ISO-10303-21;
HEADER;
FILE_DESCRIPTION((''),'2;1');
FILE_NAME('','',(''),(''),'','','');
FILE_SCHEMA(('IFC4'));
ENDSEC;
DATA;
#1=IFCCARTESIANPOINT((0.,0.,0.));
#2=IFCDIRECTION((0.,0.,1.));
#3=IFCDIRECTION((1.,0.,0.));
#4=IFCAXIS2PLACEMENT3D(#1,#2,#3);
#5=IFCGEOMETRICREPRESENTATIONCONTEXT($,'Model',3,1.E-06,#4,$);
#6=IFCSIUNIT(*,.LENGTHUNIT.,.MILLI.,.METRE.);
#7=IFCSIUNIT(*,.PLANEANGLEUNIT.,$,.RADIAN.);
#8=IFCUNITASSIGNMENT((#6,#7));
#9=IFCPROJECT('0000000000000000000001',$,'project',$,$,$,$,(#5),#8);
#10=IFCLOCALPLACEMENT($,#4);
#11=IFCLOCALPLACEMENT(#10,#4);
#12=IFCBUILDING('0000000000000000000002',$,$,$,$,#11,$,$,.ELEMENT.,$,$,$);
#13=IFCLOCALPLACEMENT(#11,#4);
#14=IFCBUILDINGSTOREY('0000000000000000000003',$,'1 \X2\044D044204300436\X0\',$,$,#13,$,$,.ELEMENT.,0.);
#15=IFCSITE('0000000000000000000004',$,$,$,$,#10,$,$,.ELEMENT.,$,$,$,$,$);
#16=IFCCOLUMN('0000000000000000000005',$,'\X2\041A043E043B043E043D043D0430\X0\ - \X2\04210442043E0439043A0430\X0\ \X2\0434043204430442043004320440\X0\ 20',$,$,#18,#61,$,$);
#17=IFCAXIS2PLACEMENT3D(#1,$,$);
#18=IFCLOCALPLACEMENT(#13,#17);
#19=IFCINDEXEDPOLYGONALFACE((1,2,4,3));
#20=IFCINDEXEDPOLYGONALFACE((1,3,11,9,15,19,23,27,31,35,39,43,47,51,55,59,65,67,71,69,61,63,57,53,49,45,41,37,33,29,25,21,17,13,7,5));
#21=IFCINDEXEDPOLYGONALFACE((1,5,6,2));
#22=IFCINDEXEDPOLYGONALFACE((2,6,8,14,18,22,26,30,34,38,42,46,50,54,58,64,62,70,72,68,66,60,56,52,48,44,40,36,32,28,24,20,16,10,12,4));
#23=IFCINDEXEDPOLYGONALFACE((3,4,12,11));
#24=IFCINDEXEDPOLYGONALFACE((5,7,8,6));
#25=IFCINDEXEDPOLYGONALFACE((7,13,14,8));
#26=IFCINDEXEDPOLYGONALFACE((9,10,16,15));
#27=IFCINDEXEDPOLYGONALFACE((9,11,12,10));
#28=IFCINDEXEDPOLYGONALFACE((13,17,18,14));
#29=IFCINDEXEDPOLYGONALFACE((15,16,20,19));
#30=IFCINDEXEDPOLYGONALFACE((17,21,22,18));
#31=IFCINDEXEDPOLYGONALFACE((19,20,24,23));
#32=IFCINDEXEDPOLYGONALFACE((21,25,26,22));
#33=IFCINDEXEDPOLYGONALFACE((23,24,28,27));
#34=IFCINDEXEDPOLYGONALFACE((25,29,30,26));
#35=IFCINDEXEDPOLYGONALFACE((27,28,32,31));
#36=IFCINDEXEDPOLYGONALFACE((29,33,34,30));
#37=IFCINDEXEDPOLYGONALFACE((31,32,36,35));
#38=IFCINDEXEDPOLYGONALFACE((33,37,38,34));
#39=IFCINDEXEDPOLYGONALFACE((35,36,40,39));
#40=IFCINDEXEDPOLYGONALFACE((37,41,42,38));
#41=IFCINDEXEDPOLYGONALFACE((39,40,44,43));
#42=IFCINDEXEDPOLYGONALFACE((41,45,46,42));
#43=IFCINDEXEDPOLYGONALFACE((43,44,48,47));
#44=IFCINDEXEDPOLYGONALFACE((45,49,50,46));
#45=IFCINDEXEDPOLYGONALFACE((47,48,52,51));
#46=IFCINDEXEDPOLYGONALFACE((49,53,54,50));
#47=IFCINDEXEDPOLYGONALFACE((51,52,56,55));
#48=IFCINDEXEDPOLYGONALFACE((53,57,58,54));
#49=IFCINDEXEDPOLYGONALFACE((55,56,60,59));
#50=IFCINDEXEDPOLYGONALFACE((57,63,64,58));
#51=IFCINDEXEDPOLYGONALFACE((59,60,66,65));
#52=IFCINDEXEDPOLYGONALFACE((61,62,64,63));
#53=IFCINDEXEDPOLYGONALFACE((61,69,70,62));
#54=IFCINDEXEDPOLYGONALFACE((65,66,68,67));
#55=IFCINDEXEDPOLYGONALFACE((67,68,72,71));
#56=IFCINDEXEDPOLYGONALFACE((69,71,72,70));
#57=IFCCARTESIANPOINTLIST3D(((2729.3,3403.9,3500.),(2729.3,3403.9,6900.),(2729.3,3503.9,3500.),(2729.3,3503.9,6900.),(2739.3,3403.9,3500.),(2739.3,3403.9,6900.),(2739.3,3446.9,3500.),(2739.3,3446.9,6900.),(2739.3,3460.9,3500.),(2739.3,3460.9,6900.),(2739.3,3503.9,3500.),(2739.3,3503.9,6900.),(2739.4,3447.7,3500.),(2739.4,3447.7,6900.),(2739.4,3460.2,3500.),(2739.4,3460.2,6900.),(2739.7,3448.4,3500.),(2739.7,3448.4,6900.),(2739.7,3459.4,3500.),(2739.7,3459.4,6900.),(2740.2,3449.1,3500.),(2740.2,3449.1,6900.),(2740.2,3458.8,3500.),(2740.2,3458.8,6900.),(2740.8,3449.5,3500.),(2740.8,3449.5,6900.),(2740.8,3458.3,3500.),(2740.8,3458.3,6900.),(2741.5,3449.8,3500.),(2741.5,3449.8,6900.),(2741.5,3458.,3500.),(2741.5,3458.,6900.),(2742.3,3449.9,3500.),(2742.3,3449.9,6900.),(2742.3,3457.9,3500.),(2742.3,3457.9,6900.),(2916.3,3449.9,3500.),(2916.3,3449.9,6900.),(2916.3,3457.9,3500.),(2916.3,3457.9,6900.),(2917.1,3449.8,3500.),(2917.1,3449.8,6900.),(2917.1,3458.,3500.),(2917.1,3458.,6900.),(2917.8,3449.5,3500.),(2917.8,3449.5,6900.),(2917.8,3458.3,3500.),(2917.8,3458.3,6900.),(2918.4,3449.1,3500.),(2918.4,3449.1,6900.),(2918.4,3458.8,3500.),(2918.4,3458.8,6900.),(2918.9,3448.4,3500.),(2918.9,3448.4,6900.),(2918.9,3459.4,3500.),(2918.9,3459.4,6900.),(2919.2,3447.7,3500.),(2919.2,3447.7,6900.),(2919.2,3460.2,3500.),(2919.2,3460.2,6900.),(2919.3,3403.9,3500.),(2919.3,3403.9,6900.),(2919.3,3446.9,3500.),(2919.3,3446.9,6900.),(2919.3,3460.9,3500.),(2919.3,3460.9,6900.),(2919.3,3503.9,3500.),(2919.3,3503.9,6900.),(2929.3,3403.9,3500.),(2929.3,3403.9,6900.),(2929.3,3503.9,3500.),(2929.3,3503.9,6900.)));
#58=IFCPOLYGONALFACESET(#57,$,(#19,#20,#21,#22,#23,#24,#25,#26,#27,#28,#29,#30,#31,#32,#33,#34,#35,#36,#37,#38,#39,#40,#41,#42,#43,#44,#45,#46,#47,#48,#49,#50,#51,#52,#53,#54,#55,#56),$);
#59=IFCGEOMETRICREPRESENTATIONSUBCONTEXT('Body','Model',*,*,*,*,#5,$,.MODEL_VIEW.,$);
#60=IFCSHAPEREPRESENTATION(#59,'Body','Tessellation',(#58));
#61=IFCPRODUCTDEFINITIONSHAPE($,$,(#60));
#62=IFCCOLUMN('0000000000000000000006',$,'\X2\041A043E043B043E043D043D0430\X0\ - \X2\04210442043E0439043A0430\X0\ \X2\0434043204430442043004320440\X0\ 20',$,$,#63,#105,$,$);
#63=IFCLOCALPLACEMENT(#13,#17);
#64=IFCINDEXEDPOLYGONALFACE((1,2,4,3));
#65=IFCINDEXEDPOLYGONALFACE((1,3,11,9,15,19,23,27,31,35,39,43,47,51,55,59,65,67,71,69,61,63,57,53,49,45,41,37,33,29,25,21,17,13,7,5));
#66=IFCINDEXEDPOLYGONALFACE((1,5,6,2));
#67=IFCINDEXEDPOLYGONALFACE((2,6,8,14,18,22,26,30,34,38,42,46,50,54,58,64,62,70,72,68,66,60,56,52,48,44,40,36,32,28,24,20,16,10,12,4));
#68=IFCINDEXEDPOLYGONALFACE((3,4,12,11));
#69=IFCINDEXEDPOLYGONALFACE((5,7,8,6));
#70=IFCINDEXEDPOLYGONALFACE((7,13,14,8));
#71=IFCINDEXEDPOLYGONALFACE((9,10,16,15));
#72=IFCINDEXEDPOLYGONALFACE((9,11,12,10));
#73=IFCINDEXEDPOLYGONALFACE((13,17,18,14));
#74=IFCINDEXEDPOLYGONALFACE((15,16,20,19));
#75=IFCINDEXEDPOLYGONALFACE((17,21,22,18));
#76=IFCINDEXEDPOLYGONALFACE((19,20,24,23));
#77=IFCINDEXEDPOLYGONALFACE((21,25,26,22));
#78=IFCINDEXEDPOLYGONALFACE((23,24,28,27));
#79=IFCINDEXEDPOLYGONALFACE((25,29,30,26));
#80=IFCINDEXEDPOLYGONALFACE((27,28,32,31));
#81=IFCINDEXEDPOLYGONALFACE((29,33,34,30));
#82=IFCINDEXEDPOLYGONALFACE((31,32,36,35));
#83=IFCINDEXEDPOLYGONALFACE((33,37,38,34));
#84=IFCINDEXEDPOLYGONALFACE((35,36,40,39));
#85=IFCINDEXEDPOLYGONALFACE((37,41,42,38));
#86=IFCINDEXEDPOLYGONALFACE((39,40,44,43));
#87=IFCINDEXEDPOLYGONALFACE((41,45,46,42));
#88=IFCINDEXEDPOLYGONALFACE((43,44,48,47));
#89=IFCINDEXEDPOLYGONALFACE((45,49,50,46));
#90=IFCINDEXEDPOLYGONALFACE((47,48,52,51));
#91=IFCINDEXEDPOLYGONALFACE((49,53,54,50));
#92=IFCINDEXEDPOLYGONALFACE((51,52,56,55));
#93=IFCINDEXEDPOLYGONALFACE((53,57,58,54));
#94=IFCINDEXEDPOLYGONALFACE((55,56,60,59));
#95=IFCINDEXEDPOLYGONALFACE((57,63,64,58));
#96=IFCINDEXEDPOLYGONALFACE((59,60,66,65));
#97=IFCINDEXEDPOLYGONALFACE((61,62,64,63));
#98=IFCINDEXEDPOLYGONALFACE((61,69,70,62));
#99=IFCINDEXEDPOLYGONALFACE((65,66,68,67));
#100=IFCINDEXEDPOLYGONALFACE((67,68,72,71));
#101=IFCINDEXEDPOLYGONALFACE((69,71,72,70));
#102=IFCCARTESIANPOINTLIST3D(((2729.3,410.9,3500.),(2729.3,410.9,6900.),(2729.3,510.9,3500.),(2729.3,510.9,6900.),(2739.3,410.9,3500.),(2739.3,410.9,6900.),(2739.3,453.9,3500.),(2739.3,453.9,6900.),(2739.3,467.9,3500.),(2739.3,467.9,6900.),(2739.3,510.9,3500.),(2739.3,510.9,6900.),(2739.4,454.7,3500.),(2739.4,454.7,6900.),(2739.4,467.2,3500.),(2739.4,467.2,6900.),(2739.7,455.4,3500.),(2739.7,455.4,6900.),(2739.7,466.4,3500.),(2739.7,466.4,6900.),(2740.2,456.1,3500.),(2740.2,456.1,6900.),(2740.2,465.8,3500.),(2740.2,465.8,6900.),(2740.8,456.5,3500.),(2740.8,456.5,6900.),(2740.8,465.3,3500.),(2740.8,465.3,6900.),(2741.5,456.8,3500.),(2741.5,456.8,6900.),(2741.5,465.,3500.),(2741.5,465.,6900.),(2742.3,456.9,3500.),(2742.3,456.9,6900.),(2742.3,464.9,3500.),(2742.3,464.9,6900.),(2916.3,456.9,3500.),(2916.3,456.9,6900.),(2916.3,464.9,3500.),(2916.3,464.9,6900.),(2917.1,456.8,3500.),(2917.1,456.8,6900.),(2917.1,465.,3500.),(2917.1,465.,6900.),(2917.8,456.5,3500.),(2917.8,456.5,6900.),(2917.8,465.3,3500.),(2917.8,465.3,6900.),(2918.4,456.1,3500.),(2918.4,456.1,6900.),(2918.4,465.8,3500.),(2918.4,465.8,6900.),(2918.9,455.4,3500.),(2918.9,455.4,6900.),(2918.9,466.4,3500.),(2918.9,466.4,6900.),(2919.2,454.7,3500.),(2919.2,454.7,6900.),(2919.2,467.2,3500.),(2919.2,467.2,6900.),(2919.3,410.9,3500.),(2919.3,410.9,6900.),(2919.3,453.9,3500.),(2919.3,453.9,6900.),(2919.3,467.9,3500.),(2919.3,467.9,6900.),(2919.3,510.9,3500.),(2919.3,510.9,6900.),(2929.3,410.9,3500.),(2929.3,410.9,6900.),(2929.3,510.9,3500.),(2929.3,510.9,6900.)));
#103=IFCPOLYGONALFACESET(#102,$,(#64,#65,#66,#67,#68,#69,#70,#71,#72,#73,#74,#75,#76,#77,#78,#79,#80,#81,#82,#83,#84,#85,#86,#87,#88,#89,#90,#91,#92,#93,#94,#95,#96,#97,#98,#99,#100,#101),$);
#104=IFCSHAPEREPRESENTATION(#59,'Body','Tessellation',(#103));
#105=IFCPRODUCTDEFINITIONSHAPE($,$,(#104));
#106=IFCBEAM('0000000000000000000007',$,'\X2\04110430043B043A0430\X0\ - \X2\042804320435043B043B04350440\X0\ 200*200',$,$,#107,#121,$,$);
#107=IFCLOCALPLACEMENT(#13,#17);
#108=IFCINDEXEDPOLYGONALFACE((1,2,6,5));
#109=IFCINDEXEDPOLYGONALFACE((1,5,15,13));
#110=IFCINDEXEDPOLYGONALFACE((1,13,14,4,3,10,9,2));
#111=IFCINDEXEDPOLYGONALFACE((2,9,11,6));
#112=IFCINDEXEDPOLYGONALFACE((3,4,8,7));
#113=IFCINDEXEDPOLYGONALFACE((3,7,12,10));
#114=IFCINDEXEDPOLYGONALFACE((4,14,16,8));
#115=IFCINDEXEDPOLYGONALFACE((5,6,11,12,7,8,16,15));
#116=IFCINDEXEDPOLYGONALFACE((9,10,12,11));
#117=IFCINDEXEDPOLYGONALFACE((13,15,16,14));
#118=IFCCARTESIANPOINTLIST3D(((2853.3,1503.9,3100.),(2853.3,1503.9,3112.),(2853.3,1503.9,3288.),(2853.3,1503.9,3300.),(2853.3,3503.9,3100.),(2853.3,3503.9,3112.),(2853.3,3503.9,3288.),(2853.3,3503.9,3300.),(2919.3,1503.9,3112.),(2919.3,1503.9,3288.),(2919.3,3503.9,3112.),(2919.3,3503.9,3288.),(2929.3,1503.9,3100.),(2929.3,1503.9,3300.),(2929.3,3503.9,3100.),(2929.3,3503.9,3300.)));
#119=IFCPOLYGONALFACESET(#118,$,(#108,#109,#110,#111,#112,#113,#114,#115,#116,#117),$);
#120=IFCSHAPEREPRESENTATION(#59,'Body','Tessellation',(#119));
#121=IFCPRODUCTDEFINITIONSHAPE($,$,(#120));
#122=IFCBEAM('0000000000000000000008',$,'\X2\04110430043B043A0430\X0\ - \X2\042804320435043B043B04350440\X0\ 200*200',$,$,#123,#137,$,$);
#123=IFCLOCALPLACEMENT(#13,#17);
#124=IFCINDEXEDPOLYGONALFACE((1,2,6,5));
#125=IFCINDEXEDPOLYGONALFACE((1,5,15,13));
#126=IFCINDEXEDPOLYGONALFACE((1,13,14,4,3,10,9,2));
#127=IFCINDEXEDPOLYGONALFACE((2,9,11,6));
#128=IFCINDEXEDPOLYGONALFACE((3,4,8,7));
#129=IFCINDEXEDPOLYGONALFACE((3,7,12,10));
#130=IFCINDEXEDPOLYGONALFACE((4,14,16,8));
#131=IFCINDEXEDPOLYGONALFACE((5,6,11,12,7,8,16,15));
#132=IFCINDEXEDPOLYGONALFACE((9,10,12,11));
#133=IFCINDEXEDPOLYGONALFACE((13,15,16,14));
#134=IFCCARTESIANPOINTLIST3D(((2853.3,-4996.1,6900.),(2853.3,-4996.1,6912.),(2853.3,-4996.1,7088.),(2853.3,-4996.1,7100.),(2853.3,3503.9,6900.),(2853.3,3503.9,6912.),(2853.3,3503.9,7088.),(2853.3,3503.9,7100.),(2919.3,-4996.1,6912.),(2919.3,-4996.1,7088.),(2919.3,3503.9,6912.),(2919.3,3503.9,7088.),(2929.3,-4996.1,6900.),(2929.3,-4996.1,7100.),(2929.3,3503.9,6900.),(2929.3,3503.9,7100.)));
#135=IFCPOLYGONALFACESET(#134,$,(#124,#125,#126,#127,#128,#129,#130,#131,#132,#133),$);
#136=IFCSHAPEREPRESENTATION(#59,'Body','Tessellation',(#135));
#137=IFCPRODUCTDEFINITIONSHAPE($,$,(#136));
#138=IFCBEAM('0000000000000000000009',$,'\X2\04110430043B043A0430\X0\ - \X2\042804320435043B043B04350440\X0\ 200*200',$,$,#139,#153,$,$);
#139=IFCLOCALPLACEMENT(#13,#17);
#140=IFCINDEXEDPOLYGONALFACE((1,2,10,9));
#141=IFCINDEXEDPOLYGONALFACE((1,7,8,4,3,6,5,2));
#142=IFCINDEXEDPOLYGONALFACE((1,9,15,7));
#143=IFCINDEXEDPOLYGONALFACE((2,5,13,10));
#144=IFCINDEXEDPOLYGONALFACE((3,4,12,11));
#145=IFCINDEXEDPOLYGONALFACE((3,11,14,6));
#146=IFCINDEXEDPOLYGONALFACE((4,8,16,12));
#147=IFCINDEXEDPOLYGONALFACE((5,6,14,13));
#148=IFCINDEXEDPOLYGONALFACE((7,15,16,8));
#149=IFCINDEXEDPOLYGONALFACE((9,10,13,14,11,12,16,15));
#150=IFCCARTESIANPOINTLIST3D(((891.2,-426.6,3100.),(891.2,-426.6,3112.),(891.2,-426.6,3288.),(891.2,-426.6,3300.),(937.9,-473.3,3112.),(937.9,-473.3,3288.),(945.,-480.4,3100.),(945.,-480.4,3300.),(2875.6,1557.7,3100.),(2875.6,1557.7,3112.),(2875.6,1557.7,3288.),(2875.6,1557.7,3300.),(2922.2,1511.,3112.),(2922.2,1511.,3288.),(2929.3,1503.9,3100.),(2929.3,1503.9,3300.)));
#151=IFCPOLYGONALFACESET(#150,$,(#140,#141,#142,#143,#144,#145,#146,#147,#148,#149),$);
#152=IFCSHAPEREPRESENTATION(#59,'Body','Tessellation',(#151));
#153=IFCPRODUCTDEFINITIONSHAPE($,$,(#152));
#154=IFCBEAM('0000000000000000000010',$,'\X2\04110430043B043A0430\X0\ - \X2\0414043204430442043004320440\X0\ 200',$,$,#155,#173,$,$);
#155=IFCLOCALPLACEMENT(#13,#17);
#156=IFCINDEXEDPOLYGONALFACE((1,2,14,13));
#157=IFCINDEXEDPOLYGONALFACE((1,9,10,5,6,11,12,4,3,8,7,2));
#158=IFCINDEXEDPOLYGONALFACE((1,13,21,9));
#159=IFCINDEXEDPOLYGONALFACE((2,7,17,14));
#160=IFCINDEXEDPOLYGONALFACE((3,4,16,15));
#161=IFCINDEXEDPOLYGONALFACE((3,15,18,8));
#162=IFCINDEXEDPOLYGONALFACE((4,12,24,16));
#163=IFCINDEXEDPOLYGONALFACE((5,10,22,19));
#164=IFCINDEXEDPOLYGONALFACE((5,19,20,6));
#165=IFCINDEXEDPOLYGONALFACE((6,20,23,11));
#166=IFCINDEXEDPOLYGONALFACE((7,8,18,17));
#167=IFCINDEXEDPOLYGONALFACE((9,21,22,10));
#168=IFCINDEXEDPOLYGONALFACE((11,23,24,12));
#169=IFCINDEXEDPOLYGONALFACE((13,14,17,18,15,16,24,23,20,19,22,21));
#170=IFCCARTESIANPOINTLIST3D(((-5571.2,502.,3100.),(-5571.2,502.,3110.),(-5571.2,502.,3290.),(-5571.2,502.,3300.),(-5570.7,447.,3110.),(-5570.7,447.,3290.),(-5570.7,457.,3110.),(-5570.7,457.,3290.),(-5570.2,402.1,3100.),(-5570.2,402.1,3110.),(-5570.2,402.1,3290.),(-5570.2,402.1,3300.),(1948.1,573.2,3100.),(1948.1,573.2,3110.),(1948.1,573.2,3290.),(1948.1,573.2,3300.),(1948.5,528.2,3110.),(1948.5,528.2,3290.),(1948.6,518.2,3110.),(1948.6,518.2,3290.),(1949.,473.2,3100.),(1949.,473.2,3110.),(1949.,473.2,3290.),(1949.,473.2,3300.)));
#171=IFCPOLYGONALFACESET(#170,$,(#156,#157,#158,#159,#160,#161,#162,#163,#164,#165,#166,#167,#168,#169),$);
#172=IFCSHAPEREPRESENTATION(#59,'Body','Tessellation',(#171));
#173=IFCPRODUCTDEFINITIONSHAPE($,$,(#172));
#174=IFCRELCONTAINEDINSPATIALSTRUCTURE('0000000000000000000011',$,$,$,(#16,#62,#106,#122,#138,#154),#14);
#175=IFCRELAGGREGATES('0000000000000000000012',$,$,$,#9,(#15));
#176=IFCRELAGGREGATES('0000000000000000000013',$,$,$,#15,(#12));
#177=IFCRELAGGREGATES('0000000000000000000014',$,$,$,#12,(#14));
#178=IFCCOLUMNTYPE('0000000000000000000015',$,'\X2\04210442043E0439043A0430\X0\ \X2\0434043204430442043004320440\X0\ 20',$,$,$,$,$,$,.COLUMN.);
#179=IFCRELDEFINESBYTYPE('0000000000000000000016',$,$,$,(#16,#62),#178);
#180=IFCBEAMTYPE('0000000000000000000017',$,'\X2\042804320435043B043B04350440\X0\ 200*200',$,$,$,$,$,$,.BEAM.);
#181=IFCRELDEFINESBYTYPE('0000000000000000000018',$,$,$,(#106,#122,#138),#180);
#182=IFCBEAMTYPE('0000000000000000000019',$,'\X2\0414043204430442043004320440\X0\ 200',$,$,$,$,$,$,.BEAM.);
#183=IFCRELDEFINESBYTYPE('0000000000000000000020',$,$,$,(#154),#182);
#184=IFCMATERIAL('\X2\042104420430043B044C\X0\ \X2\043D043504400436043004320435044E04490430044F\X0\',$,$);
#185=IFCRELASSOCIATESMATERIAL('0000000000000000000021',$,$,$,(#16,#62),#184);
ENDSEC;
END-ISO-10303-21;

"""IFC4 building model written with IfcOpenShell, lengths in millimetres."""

from ifc_helpers import new_model, si_unit, frame, origin_with_axes, place, context, subcontext, project, spatial, line, arc, indexed_curve, outline, extrude, source, transform, mapped, material, type_object, element, save


model = new_model("IFC4")

# Units and contexts
model_context = context("Model", 3, precision=1e-06, world=origin_with_axes())
body_context = subcontext(model_context, "Body", "Model", "MODEL_VIEW")
ifc_project = project(units=[si_unit("LENGTHUNIT", "METRE", prefix="MILLI"), si_unit("PLANEANGLEUNIT", "RADIAN")], contexts=[model_context])

# Site, building, storey
site_placement = place(None, origin_with_axes())
site = spatial("IfcSite", under=ifc_project, at=site_placement, CompositionType="ELEMENT")
building_placement = place(site_placement, origin_with_axes())
building = spatial("IfcBuilding", under=site, at=building_placement, CompositionType="ELEMENT")
storey_placement = place(building_placement, origin_with_axes())
storey = spatial("IfcBuildingStorey", under=building, at=storey_placement, Name="1 этаж", CompositionType="ELEMENT", Elevation=0.0)

# Columns
ifc_material_1 = material(Name="Сталь нержавеющая")
column_type = type_object("IfcColumnType", Name="Стойка двутавр 20", PredefinedType="COLUMN")
shared_shape_1 = source(origin_with_axes(), body_context, "Body", "SweptSolid", [
    extrude(outline(indexed_curve([(-50.0, -100.0), (50.0, -100.0), (50.0, -90.0), (7.0, -90.0), (4.9, -89.1), (4.0, -87.0), (4.0, 87.0), (4.9, 89.1), (7.0, 90.0), (50.0, 90.0), (50.0, 100.0), (-50.0, 100.0), (-50.0, 90.0), (-7.0, 90.0), (-4.9, 89.1), (-4.0, 87.0), (-4.0, -87.0), (-4.9, -89.1), (-7.0, -90.0), (-50.0, -90.0)], segments=[line(1, 2), line(2, 3), line(3, 4), arc(4, 5, 6), line(6, 7), arc(7, 8, 9), line(9, 10), line(10, 11), line(11, 12), line(12, 13), line(13, 14), arc(14, 15, 16), line(16, 17), arc(17, 18, 19), line(19, 20), line(20, 1)])), origin_with_axes(), (0.0, 0.0, 1.0), 3400.0),
])
for number, where, z_axis, x_axis, name in (
    (1, (2829.3, 3453.9, 3500.0), (0.0, 0.0, 1.0), (0.0, -1.0, 0.0), "Колонна - Стойка двутавр 20"),
    (2, (2829.3, 460.9, 3500.0), (0.0, 0.0, 1.0), (0.0, -1.0, 0.0), "Колонна - Стойка двутавр 20"),
):
    element("IfcColumn", number, at=place(storey_placement, frame(where, z_axis=z_axis, x_axis=x_axis)), inside=storey, type_object=column_type, material=ifc_material_1, Name=name, context=body_context, shape_type="MappedRepresentation", body=[
        mapped(shared_shape_1, transform((0.0, 0.0, 0.0), x_axis=(1.0, 0.0, 0.0), y_axis=(0.0, 1.0, 0.0), z_axis=(0.0, 0.0, 1.0), scale=1.0)),
    ])

# Beams
beam_type_1 = type_object("IfcBeamType", Name="Швеллер 200*200", PredefinedType="BEAM")
shared_shape_2 = source(origin_with_axes(), body_context, "Body", "SweptSolid", [
    extrude(outline(indexed_curve([(0.0, 0.0), (76.0, 0.0), (76.0, 12.0), (10.0, 12.0), (10.0, 188.0), (76.0, 188.0), (76.0, 200.0), (0.0, 200.0)], segments=[line(1, 2), line(2, 3), line(3, 4), line(4, 5), line(5, 6), line(6, 7), line(7, 8), line(8, 1)])), origin_with_axes(), (0.0, 0.0, -1.0), 2000.0),
])
beam_1_placement = place(storey_placement, frame((2929.3, 3503.9, 3100.0), z_axis=(0.0, 1.0, 0.0), x_axis=(-1.0, 0.0, 0.0)))
element("IfcBeam", 3, at=beam_1_placement, inside=storey, type_object=beam_type_1, Name="Балка - Швеллер 200*200", context=body_context, shape_type="MappedRepresentation", body=[
    mapped(shared_shape_2, transform((0.0, 0.0, 0.0), x_axis=(1.0, 0.0, 0.0), y_axis=(0.0, 1.0, 0.0), z_axis=(0.0, 0.0, 1.0), scale=1.0)),
])
shared_shape_3 = source(origin_with_axes(), body_context, "Body", "SweptSolid", [
    extrude(outline(indexed_curve([(0.0, 0.0), (76.0, 0.0), (76.0, 12.0), (10.0, 12.0), (10.0, 188.0), (76.0, 188.0), (76.0, 200.0), (0.0, 200.0)], segments=[line(1, 2), line(2, 3), line(3, 4), line(4, 5), line(5, 6), line(6, 7), line(7, 8), line(8, 1)])), origin_with_axes(), (0.0, 0.0, -1.0), 8500.0),
])
beam_2_placement = place(storey_placement, frame((2929.3, 3503.9, 6900.0), z_axis=(0.0, 1.0, 0.0), x_axis=(-1.0, 0.0, 0.0)))
element("IfcBeam", 4, at=beam_2_placement, inside=storey, type_object=beam_type_1, Name="Балка - Швеллер 200*200", context=body_context, shape_type="MappedRepresentation", body=[
    mapped(shared_shape_3, transform((0.0, 0.0, 0.0), x_axis=(1.0, 0.0, 0.0), y_axis=(0.0, 1.0, 0.0), z_axis=(0.0, 0.0, 1.0), scale=1.0)),
])
shared_shape_4 = source(origin_with_axes(), body_context, "Body", "SweptSolid", [
    extrude(outline(indexed_curve([(0.0, 0.0), (76.0, 0.0), (76.0, 12.0), (10.0, 12.0), (10.0, 188.0), (76.0, 188.0), (76.0, 200.0), (0.0, 200.0)], segments=[line(1, 2), line(2, 3), line(3, 4), line(4, 5), line(5, 6), line(6, 7), line(7, 8), line(8, 1)])), origin_with_axes(), (0.0, 0.0, -1.0), 2806.2),
])
beam_3_placement = place(storey_placement, frame((2929.3, 1503.9, 3100.0), z_axis=(0.707107, 0.707107, 0.0), x_axis=(-0.707107, 0.707107, 0.0)))
element("IfcBeam", 5, at=beam_3_placement, inside=storey, type_object=beam_type_1, Name="Балка - Швеллер 200*200", context=body_context, shape_type="MappedRepresentation", body=[
    mapped(shared_shape_4, transform((0.0, 0.0, 0.0), x_axis=(1.0, 0.0, 0.0), y_axis=(0.0, 1.0, 0.0), z_axis=(0.0, 0.0, 1.0), scale=1.0)),
])
beam_type_2 = type_object("IfcBeamType", Name="Двутавр 200", PredefinedType="BEAM")
shared_shape_5 = source(origin_with_axes(), body_context, "Body", "SweptSolid", [
    extrude(outline(indexed_curve([(-50.0, 0.0), (50.0, 0.0), (50.0, 10.0), (5.0, 10.0), (5.0, 190.0), (50.0, 190.0), (50.0, 200.0), (-50.0, 200.0), (-50.0, 190.0), (-5.0, 190.0), (-5.0, 10.0), (-50.0, 10.0)], segments=[line(1, 2), line(2, 3), line(3, 4), line(4, 5), line(5, 6), line(6, 7), line(7, 8), line(8, 9), line(9, 10), line(10, 11), line(11, 12), line(12, 1)])), origin_with_axes(), (0.0, 0.0, -1.0), 7519.6),
])
beam_4_placement = place(storey_placement, frame((1948.5, 523.2, 3100.0), z_axis=(0.999955, 0.009459, 0.0), x_axis=(-0.009459, 0.999955, 0.0)))
element("IfcBeam", 6, at=beam_4_placement, inside=storey, type_object=beam_type_2, Name="Балка - Двутавр 200", context=body_context, shape_type="MappedRepresentation", body=[
    mapped(shared_shape_5, transform((0.0, 0.0, 0.0), x_axis=(1.0, 0.0, 0.0), y_axis=(0.0, 1.0, 0.0), z_axis=(0.0, 0.0, 1.0), scale=1.0)),
])

save(model, "model.ifc")
